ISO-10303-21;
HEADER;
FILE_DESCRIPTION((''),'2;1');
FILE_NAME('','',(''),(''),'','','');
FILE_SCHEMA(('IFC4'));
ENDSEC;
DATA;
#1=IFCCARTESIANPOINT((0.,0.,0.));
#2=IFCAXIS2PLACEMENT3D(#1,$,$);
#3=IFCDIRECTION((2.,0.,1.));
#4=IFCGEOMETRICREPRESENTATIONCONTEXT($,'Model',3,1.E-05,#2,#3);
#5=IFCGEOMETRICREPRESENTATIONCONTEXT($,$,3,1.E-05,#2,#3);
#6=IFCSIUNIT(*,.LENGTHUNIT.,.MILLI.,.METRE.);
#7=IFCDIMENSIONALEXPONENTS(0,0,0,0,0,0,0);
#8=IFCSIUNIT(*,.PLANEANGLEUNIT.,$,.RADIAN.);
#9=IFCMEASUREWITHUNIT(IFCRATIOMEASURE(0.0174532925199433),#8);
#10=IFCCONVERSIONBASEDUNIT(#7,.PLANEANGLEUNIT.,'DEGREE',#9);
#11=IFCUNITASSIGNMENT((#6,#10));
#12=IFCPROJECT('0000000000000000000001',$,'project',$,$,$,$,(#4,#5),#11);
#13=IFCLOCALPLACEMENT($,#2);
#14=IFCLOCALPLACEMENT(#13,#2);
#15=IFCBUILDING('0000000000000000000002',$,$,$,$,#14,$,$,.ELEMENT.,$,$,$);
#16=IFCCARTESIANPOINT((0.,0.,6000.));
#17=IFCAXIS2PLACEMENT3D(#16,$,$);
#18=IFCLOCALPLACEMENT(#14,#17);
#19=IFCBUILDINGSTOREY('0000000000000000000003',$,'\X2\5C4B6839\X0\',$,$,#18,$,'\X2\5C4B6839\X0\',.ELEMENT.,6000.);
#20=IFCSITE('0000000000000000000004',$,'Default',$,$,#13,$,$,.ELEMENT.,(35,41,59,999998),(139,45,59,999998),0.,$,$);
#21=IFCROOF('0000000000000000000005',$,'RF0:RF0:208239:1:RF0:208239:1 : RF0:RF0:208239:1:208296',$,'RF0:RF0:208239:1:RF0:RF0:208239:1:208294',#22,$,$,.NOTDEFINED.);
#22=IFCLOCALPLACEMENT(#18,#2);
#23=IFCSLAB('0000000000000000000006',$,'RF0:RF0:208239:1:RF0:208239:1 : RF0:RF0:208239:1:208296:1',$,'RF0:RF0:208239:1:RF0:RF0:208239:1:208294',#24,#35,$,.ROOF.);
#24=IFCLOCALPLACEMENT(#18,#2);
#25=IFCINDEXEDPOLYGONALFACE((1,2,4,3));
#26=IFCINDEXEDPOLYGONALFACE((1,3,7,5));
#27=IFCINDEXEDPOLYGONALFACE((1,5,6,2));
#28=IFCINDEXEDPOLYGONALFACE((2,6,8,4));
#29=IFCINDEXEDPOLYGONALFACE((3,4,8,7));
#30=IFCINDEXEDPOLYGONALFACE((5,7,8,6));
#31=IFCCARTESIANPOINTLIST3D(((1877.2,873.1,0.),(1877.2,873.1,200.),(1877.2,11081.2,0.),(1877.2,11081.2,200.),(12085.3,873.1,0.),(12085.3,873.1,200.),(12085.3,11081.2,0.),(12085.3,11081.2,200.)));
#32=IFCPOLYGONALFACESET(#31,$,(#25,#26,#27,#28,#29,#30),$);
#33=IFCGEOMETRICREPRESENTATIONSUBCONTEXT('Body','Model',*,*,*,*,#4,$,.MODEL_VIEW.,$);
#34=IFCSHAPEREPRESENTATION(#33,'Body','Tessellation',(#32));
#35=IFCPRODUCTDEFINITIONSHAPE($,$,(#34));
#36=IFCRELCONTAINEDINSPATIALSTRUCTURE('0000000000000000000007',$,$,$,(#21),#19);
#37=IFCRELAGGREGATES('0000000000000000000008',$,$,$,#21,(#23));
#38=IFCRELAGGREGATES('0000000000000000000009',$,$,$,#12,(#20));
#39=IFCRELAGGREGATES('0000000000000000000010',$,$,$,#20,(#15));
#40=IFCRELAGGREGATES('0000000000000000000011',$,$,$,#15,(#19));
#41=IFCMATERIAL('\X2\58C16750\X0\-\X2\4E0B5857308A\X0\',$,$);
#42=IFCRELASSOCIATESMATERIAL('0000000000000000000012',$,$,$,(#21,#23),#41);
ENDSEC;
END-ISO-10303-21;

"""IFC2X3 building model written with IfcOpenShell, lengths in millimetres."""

from ifc_helpers import new_model, entity, si_unit, converted_unit, direction, frame, origin, origin_2d_with_axis, place, context, subcontext, project, spatial, rectangle, extrude, material, element, aggregate, save


model = new_model("IFC2X3")

# Units and contexts
model_context = context("Model", 3, precision=1e-05, world=origin(), true_north=direction((2.0, 0.0, 1.0)))
context_of_model = context(None, 3, precision=1e-05, world=origin(), true_north=direction((2.0, 0.0, 1.0)))
body_context = subcontext(model_context, "Body", "Model", "MODEL_VIEW")
ifc_project = project(units=[si_unit("LENGTHUNIT", "METRE", prefix="MILLI"), converted_unit("PLANEANGLEUNIT", "DEGREE", entity("IfcRatioMeasure", 0.0174532925199433), si_unit("PLANEANGLEUNIT", "RADIAN"), dimensions=[0, 0, 0, 0, 0, 0, 0])], contexts=[model_context, context_of_model])

# Site, building, storey
site_placement = place(None, origin())
site = spatial("IfcSite", under=ifc_project, at=site_placement, Name="Default", CompositionType="ELEMENT", RefLatitude=(35, 41, 59, 999998), RefLongitude=(139, 45, 59, 999998), RefElevation=0.0)
building_placement = place(site_placement, origin())
building = spatial("IfcBuilding", under=site, at=building_placement, CompositionType="ELEMENT")
storey_placement = place(building_placement, frame((0.0, 0.0, 6000.0)))
storey = spatial("IfcBuildingStorey", under=building, at=storey_placement, Name="屋根", LongName="屋根", CompositionType="ELEMENT", Elevation=6000.0)

# Roof, slab
ifc_material = material(Name="壁材-下塗り")
roof_placement = place(storey_placement, origin())
roof = element("IfcRoof", 1, at=roof_placement, inside=storey, material=ifc_material, Name="RF0:RF0:208239:1:RF0:208239:1 : RF0:RF0:208239:1:208296", ObjectType="RF0:RF0:208239:1:RF0:RF0:208239:1:208294", ShapeType="NOTDEFINED")
slab_placement = place(storey_placement, origin())
slab = element("IfcSlab", 2, at=slab_placement, material=ifc_material, Name="RF0:RF0:208239:1:RF0:208239:1 : RF0:RF0:208239:1:208296:1", ObjectType="RF0:RF0:208239:1:RF0:RF0:208239:1:208294", PredefinedType="ROOF", context=body_context, shape_type="SweptSolid", body=[
    extrude(rectangle(XDim=10208.1, YDim=10208.1, at=origin_2d_with_axis()), frame((6981.3, 5977.2, 0.0), z_axis=(0.0, 0.0, 1.0), x_axis=(0.0, -1.0, 0.0)), (0.0, 0.0, 1.0), 200.0),
])
aggregate(roof, [slab])

save(model, "model.ifc")
